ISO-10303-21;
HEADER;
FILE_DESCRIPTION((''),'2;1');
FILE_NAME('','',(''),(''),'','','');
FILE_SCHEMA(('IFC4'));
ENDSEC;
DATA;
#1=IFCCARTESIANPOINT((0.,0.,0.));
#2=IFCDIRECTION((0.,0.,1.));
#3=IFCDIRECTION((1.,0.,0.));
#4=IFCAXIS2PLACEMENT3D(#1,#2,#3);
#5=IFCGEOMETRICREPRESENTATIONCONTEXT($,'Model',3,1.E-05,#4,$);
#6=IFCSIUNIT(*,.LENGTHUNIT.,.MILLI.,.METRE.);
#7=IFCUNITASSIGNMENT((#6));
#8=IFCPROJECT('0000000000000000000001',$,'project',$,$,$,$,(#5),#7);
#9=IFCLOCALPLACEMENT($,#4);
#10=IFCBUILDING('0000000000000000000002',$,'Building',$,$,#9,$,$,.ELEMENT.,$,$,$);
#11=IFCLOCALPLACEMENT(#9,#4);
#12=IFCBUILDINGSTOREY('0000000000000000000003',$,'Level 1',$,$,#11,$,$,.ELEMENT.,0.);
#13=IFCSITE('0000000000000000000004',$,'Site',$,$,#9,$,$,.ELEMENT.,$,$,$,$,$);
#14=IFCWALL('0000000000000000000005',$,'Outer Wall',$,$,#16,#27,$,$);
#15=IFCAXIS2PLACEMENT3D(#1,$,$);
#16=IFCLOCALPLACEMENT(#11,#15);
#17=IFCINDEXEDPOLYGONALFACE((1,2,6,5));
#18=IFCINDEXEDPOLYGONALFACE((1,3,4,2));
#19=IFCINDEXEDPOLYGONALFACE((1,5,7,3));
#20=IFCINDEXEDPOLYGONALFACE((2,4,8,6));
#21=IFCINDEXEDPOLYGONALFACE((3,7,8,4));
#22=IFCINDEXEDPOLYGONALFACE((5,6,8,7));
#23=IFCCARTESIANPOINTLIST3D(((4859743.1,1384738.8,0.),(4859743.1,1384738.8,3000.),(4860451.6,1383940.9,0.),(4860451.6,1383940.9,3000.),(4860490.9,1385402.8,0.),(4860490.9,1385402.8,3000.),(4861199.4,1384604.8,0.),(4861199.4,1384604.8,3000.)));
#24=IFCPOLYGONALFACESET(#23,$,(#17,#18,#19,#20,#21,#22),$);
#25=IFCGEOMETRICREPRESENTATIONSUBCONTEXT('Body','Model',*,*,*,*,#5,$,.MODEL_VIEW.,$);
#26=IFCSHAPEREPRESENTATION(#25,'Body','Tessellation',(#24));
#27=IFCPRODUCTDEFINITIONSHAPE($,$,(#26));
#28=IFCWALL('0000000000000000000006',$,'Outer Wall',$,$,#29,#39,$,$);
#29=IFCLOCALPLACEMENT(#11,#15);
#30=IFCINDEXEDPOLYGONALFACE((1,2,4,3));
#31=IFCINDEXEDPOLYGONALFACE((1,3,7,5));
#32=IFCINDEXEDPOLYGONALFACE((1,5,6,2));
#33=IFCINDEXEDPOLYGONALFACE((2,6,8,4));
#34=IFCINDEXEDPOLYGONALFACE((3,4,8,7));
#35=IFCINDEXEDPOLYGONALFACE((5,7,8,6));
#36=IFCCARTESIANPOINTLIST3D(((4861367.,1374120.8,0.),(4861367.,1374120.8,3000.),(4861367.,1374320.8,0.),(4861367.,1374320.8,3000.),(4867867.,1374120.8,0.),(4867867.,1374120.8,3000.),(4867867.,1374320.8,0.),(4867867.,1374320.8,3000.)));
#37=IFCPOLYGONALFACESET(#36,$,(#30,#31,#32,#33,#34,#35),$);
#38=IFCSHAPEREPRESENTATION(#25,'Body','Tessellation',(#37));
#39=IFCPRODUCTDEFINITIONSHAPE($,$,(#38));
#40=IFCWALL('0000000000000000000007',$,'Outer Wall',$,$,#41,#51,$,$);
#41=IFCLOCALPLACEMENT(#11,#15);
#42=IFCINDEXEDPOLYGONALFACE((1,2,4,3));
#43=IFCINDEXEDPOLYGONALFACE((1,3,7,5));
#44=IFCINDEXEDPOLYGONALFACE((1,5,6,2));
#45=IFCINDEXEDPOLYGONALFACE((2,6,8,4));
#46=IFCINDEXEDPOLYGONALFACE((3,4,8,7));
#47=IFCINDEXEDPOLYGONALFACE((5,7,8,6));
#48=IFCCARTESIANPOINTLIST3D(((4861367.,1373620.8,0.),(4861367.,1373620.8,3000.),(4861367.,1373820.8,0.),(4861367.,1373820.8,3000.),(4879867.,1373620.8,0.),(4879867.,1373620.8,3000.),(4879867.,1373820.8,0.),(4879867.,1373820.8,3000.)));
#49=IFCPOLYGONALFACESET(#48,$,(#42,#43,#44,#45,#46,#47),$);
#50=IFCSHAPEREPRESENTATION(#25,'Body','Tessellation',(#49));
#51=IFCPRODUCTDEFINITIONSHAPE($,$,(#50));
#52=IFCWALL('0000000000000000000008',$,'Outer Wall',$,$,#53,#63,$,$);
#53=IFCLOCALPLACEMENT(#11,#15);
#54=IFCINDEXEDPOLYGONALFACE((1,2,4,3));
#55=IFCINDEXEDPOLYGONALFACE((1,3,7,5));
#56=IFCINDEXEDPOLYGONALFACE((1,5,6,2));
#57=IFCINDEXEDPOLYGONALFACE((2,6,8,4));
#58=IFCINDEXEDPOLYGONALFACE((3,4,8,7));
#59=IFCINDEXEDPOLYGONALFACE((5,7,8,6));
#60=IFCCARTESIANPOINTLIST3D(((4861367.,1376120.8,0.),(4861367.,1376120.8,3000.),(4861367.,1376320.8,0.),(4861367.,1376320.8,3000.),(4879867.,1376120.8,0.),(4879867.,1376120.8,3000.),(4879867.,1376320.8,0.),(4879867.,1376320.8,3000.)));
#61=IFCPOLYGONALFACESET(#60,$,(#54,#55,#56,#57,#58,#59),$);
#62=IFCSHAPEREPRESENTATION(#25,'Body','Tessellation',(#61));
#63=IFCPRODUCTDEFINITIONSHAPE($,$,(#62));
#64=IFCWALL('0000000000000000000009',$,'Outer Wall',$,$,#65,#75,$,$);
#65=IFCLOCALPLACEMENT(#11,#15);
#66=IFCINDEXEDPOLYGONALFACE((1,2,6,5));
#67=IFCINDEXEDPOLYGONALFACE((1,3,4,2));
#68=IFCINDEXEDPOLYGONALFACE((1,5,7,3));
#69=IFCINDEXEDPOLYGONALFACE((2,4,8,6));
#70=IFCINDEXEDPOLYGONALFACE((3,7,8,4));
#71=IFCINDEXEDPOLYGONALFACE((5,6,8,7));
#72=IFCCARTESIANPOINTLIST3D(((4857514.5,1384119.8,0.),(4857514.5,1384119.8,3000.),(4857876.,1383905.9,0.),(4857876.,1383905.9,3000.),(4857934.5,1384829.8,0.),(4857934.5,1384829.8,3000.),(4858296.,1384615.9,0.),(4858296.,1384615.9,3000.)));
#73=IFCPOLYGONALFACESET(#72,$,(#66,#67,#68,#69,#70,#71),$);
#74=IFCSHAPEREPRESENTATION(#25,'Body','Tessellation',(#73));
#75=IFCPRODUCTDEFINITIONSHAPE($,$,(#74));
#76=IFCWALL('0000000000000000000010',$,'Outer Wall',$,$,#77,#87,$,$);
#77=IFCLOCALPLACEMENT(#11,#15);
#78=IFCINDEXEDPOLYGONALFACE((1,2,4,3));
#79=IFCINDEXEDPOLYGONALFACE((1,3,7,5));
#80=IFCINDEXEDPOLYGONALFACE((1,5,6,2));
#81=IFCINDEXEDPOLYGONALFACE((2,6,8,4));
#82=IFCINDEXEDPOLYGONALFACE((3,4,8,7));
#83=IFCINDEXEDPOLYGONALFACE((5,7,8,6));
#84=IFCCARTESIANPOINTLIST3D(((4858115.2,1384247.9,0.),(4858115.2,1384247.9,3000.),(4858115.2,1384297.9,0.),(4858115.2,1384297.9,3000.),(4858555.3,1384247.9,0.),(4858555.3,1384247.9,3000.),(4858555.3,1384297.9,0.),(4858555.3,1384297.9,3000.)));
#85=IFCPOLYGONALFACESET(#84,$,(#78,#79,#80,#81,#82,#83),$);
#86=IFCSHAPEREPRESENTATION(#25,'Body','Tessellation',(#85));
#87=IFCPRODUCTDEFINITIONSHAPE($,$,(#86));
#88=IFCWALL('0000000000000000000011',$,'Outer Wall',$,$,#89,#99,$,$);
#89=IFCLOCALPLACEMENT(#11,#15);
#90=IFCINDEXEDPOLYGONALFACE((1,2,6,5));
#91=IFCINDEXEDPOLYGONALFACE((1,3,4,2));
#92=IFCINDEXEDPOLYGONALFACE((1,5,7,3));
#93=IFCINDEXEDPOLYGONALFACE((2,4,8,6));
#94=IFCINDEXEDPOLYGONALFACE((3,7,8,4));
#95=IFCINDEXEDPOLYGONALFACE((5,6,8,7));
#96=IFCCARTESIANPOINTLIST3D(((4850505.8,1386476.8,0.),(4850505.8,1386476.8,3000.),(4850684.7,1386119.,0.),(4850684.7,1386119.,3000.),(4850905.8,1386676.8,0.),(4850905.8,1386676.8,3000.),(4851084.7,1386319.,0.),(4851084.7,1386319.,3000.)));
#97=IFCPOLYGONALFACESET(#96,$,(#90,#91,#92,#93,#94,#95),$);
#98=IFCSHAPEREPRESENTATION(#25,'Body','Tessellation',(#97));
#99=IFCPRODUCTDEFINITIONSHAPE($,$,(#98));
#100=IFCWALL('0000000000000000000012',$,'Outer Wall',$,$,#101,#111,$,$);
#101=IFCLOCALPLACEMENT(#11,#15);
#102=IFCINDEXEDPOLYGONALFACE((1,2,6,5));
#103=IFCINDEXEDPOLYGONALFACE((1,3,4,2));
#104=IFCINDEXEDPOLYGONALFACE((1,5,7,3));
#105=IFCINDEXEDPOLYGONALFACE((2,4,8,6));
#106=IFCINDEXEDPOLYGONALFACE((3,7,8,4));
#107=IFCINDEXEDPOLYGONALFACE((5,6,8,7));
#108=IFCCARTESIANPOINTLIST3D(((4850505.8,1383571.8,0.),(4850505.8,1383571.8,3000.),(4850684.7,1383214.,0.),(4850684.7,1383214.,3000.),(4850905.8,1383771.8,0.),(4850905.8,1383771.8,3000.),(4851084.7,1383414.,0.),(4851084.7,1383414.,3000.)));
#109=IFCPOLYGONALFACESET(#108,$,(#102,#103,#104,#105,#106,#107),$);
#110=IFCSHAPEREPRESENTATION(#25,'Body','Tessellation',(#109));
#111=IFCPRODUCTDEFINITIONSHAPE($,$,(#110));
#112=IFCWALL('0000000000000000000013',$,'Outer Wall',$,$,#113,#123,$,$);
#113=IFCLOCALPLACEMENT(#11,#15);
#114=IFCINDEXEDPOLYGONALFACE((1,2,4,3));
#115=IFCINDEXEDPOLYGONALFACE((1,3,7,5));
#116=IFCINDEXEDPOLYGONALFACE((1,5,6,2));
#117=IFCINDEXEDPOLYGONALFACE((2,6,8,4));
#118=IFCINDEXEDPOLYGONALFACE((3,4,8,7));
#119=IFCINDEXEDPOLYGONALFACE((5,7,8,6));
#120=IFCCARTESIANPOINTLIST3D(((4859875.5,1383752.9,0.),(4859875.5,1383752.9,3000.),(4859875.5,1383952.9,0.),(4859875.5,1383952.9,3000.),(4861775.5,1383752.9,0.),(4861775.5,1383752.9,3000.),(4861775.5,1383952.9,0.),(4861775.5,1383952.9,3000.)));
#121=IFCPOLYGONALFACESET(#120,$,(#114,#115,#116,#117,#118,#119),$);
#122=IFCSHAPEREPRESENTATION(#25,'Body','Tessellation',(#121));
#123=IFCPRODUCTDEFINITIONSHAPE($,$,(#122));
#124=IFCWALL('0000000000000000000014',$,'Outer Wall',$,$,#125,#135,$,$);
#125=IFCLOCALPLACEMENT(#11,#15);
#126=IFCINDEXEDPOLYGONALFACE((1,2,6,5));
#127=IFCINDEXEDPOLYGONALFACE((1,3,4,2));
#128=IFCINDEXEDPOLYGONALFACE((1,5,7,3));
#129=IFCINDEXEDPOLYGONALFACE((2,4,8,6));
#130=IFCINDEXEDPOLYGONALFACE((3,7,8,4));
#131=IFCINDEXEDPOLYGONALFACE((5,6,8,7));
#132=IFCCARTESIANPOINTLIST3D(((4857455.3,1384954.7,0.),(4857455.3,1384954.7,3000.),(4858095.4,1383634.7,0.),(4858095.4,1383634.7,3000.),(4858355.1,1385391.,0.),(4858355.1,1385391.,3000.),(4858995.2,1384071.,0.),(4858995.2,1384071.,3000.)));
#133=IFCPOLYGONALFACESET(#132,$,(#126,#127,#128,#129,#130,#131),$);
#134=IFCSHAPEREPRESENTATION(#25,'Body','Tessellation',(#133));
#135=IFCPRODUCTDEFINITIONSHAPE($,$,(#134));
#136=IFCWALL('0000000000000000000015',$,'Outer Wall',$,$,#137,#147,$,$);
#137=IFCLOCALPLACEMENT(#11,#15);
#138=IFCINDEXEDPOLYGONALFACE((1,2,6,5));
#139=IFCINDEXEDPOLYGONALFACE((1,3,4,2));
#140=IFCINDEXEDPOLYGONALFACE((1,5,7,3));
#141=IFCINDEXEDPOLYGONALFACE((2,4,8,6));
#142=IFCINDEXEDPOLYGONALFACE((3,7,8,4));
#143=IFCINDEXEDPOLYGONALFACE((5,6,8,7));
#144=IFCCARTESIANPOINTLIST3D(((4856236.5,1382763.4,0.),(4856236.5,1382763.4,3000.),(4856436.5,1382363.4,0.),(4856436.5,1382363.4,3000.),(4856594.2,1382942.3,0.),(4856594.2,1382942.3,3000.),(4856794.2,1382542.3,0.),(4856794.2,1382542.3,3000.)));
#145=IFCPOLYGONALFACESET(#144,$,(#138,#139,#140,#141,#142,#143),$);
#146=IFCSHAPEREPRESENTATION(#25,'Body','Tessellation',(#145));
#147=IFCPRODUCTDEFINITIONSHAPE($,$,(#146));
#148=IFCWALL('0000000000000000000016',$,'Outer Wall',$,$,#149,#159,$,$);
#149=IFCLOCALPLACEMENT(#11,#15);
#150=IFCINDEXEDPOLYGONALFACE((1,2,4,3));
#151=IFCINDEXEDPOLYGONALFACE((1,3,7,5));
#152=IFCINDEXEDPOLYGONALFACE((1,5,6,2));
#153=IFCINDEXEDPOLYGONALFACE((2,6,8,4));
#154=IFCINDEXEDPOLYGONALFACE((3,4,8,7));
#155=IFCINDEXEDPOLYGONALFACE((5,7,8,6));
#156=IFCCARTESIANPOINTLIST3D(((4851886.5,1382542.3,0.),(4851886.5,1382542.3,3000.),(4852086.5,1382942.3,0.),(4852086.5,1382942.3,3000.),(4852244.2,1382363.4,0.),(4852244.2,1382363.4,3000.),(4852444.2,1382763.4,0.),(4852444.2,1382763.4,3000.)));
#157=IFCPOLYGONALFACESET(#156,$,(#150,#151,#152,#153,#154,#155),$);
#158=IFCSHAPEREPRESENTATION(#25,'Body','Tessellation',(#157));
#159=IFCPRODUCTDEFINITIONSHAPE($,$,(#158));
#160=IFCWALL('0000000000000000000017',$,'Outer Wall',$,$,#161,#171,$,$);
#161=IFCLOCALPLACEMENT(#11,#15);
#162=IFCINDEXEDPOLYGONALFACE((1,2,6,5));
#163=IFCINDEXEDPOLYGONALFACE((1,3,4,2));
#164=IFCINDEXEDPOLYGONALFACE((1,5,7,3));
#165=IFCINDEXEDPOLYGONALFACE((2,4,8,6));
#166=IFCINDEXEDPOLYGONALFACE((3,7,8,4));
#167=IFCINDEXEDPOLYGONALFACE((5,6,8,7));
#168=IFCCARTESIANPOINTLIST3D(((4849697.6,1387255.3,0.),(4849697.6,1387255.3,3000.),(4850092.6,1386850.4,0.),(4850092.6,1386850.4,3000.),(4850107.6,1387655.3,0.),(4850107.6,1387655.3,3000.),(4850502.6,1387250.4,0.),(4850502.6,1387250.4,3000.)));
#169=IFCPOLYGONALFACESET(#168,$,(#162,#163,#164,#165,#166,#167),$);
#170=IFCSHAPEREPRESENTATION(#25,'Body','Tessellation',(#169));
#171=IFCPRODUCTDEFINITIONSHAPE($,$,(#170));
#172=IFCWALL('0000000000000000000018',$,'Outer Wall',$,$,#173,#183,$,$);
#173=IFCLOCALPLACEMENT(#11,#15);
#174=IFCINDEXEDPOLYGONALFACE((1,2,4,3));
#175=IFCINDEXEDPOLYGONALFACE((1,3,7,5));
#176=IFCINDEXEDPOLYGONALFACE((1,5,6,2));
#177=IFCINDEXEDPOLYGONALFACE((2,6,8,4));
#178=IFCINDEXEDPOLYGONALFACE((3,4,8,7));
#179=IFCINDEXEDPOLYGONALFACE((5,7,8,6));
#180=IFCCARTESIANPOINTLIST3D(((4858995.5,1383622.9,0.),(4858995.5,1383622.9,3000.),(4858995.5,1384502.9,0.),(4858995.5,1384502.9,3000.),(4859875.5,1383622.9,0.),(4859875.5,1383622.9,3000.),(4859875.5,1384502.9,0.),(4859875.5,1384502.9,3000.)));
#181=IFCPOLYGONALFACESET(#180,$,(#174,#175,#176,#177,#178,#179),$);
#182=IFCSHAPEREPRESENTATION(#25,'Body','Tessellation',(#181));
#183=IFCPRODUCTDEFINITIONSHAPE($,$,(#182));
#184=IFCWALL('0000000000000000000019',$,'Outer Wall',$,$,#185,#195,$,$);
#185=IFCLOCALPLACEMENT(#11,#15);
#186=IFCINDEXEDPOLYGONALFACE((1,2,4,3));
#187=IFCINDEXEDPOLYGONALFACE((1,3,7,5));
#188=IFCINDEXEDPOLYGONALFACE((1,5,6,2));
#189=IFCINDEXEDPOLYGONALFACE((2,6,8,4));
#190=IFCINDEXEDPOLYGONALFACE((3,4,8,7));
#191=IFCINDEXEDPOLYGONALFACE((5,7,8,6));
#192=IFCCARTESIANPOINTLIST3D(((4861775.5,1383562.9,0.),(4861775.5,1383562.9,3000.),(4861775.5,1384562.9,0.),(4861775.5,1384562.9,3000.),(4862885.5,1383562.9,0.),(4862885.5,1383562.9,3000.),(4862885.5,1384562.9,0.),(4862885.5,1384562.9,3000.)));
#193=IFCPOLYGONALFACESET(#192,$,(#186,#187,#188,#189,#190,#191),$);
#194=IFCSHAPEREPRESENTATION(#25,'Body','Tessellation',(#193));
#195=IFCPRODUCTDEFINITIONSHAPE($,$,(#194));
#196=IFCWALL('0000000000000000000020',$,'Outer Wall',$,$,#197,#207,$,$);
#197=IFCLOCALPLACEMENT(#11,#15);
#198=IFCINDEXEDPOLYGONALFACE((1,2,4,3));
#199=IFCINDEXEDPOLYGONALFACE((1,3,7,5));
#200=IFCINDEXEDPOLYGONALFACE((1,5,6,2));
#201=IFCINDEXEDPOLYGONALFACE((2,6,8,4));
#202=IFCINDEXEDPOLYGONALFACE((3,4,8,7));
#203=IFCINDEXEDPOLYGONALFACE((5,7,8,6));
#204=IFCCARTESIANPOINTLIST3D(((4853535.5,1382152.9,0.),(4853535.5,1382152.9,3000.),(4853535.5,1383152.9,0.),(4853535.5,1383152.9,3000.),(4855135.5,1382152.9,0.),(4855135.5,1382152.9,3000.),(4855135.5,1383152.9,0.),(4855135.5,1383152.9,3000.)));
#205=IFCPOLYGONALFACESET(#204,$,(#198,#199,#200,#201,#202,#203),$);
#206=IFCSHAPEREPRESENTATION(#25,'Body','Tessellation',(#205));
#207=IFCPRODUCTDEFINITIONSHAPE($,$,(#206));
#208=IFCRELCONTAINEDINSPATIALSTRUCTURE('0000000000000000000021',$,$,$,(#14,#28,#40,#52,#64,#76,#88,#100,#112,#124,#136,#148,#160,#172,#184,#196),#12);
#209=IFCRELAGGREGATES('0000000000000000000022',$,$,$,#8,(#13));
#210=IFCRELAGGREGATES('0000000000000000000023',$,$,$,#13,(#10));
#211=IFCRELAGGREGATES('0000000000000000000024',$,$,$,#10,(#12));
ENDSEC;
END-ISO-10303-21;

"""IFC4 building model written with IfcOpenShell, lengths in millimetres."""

from ifc_helpers import new_model, si_unit, frame, frame_2d, origin_with_axes, place, context, subcontext, project, spatial, rectangle, extrude, element, save


model = new_model("IFC4")

# Units and contexts
model_context = context("Model", 3, precision=1e-05, world=origin_with_axes())
body_context = subcontext(model_context, "Body", "Model", "MODEL_VIEW")
ifc_project = project(units=[si_unit("LENGTHUNIT", "METRE", prefix="MILLI")], contexts=[model_context])

# Site, building, storey
placement = place(None, origin_with_axes())
site = spatial("IfcSite", under=ifc_project, at=placement, Name="Site", CompositionType="ELEMENT")
building = spatial("IfcBuilding", under=site, at=placement, Name="Building", CompositionType="ELEMENT")
storey_placement = place(placement, origin_with_axes())
storey = spatial("IfcBuildingStorey", under=building, at=storey_placement, Name="Level 1", CompositionType="ELEMENT", Elevation=0.0)

# Walls
wall_1_placement = place(placement, frame((4860117.0, 1385070.8, 0.0), z_axis=(0.0, 0.0, 1.0), x_axis=(0.663934, -0.747791, 0.0)))
element("IfcWall", 1, at=wall_1_placement, inside=storey, Name="Outer Wall", context=body_context, shape_type="SweptSolid", body=[
    extrude(rectangle(XDim=1067.0, YDim=1000.0, at=frame_2d((533.5, 0.0), x_axis=(1.0, 0.0))), origin_with_axes(), (0.0, 0.0, 1.0), 3000.0),
])
wall_2_placement = place(placement, frame((4861367.0, 1374220.8, 0.0), z_axis=(0.0, 0.0, 1.0), x_axis=(1.0, 0.0, 0.0)))
element("IfcWall", 2, at=wall_2_placement, inside=storey, Name="Outer Wall", context=body_context, shape_type="SweptSolid", body=[
    extrude(rectangle(XDim=6500.0, YDim=200.0, at=frame_2d((3250.0, 0.0), x_axis=(1.0, 0.0))), origin_with_axes(), (0.0, 0.0, 1.0), 3000.0),
])
for number, where, z_axis, x_axis, name in (
    (3, (4861367.0, 1373720.8, 0.0), (0.0, 0.0, 1.0), (1.0, 0.0, 0.0), "Outer Wall"),
    (4, (4861367.0, 1376220.8, 0.0), (0.0, 0.0, 1.0), (1.0, 0.0, 0.0), "Outer Wall"),
):
    element("IfcWall", number, at=place(placement, frame(where, z_axis=z_axis, x_axis=x_axis)), inside=storey, Name=name, context=body_context, shape_type="SweptSolid", body=[
        extrude(rectangle(XDim=18500.0, YDim=200.0, at=frame_2d((9250.0, 0.0), x_axis=(1.0, 0.0))), origin_with_axes(), (0.0, 0.0, 1.0), 3000.0),
    ])
wall_3_placement = place(placement, frame((4857695.2, 1384012.9, 0.0), z_axis=(0.0, 0.0, 1.0), x_axis=(0.509138, 0.860685, 0.0)))
element("IfcWall", 5, at=wall_3_placement, inside=storey, Name="Outer Wall", context=body_context, shape_type="SweptSolid", body=[
    extrude(rectangle(XDim=824.9, YDim=420.0, at=frame_2d((412.5, 0.0), x_axis=(1.0, 0.0))), origin_with_axes(), (0.0, 0.0, 1.0), 3000.0),
])
wall_4_placement = place(placement, frame((4858115.2, 1384272.9, 0.0), z_axis=(0.0, 0.0, 1.0), x_axis=(1.0, 0.0, 0.0)))
element("IfcWall", 6, at=wall_4_placement, inside=storey, Name="Outer Wall", context=body_context, shape_type="SweptSolid", body=[
    extrude(rectangle(XDim=440.1, YDim=50.0, at=frame_2d((220.1, 0.0), x_axis=(1.0, 0.0))), origin_with_axes(), (0.0, 0.0, 1.0), 3000.0),
])
wall_5_placement = place(placement, frame((4850995.2, 1386497.9, 0.0), z_axis=(0.0, 0.0, 1.0), x_axis=(-0.894427, -0.447214, 0.0)))
element("IfcWall", 7, at=wall_5_placement, inside=storey, Name="Outer Wall", context=body_context, shape_type="SweptSolid", body=[
    extrude(rectangle(XDim=447.2, YDim=400.0, at=frame_2d((223.6, 0.0), x_axis=(1.0, 0.0))), origin_with_axes(), (0.0, 0.0, 1.0), 3000.0),
])
wall_6_placement = place(placement, frame((4850995.2, 1383592.9, 0.0), z_axis=(0.0, 0.0, 1.0), x_axis=(-0.894427, -0.447214, 0.0)))
element("IfcWall", 8, at=wall_6_placement, inside=storey, Name="Outer Wall", context=body_context, shape_type="SweptSolid", body=[
    extrude(rectangle(XDim=447.2, YDim=400.0, at=frame_2d((223.6, 0.0), x_axis=(1.0, 0.0))), origin_with_axes(), (0.0, 0.0, 1.0), 3000.0),
])
wall_7_placement = place(placement, frame((4861775.5, 1383852.9, 0.0), z_axis=(0.0, 0.0, 1.0), x_axis=(-1.0, 0.0, 0.0)))
element("IfcWall", 9, at=wall_7_placement, inside=storey, Name="Outer Wall", context=body_context, shape_type="SweptSolid", body=[
    extrude(rectangle(XDim=1900.0, YDim=200.0, at=frame_2d((950.0, 0.0), x_axis=(1.0, 0.0))), origin_with_axes(), (0.0, 0.0, 1.0), 3000.0),
])
wall_8_placement = place(placement, frame((4858545.3, 1383852.9, 0.0), z_axis=(0.0, 0.0, 1.0), x_axis=(-0.436338, 0.899783, 0.0)))
element("IfcWall", 10, at=wall_8_placement, inside=storey, Name="Outer Wall", context=body_context, shape_type="SweptSolid", body=[
    extrude(rectangle(XDim=1467.0, YDim=1000.0, at=frame_2d((733.5, 0.0), x_axis=(1.0, 0.0))), origin_with_axes(), (0.0, 0.0, 1.0), 3000.0),
])
wall_9_placement = place(placement, frame((4856415.4, 1382852.9, 0.0), z_axis=(0.0, 0.0, 1.0), x_axis=(0.447214, -0.894427, 0.0)))
element("IfcWall", 11, at=wall_9_placement, inside=storey, Name="Outer Wall", context=body_context, shape_type="SweptSolid", body=[
    extrude(rectangle(XDim=447.2, YDim=400.0, at=frame_2d((223.6, 0.0), x_axis=(1.0, 0.0))), origin_with_axes(), (0.0, 0.0, 1.0), 3000.0),
])
wall_10_placement = place(placement, frame((4852265.4, 1382852.9, 0.0), z_axis=(0.0, 0.0, 1.0), x_axis=(-0.447214, -0.894427, 0.0)))
element("IfcWall", 12, at=wall_10_placement, inside=storey, Name="Outer Wall", context=body_context, shape_type="SweptSolid", body=[
    extrude(rectangle(XDim=447.2, YDim=400.0, at=frame_2d((223.6, 0.0), x_axis=(1.0, 0.0))), origin_with_axes(), (0.0, 0.0, 1.0), 3000.0),
])
wall_11_placement = place(placement, frame((4849895.1, 1387052.9, 0.0), z_axis=(0.0, 0.0, 1.0), x_axis=(0.715782, 0.698324, 0.0)))
element("IfcWall", 13, at=wall_11_placement, inside=storey, Name="Outer Wall", context=body_context, shape_type="SweptSolid", body=[
    extrude(rectangle(XDim=572.8, YDim=565.7, at=frame_2d((286.4, 0.0), x_axis=(1.0, 0.0))), origin_with_axes(), (0.0, 0.0, 1.0), 3000.0),
])
wall_12_placement = place(placement, frame((4858995.5, 1384062.9, 0.0), z_axis=(0.0, 0.0, 1.0), x_axis=(1.0, 0.0, 0.0)))
element("IfcWall", 14, at=wall_12_placement, inside=storey, Name="Outer Wall", context=body_context, shape_type="SweptSolid", body=[
    extrude(rectangle(XDim=880.0, YDim=880.0, at=frame_2d((440.0, 0.0), x_axis=(1.0, 0.0))), origin_with_axes(), (0.0, 0.0, 1.0), 3000.0),
])
wall_13_placement = place(placement, frame((4861775.5, 1384062.9, 0.0), z_axis=(0.0, 0.0, 1.0), x_axis=(1.0, 0.0, 0.0)))
element("IfcWall", 15, at=wall_13_placement, inside=storey, Name="Outer Wall", context=body_context, shape_type="SweptSolid", body=[
    extrude(rectangle(XDim=1110.0, YDim=1000.0, at=frame_2d((555.0, 0.0), x_axis=(1.0, 0.0))), origin_with_axes(), (0.0, 0.0, 1.0), 3000.0),
])
wall_14_placement = place(placement, frame((4855135.5, 1382652.9, 0.0), z_axis=(0.0, 0.0, 1.0), x_axis=(-1.0, 0.0, 0.0)))
element("IfcWall", 16, at=wall_14_placement, inside=storey, Name="Outer Wall", context=body_context, shape_type="SweptSolid", body=[
    extrude(rectangle(XDim=1600.0, YDim=1000.0, at=frame_2d((800.0, 0.0), x_axis=(1.0, 0.0))), origin_with_axes(), (0.0, 0.0, 1.0), 3000.0),
])

save(model, "model.ifc")
